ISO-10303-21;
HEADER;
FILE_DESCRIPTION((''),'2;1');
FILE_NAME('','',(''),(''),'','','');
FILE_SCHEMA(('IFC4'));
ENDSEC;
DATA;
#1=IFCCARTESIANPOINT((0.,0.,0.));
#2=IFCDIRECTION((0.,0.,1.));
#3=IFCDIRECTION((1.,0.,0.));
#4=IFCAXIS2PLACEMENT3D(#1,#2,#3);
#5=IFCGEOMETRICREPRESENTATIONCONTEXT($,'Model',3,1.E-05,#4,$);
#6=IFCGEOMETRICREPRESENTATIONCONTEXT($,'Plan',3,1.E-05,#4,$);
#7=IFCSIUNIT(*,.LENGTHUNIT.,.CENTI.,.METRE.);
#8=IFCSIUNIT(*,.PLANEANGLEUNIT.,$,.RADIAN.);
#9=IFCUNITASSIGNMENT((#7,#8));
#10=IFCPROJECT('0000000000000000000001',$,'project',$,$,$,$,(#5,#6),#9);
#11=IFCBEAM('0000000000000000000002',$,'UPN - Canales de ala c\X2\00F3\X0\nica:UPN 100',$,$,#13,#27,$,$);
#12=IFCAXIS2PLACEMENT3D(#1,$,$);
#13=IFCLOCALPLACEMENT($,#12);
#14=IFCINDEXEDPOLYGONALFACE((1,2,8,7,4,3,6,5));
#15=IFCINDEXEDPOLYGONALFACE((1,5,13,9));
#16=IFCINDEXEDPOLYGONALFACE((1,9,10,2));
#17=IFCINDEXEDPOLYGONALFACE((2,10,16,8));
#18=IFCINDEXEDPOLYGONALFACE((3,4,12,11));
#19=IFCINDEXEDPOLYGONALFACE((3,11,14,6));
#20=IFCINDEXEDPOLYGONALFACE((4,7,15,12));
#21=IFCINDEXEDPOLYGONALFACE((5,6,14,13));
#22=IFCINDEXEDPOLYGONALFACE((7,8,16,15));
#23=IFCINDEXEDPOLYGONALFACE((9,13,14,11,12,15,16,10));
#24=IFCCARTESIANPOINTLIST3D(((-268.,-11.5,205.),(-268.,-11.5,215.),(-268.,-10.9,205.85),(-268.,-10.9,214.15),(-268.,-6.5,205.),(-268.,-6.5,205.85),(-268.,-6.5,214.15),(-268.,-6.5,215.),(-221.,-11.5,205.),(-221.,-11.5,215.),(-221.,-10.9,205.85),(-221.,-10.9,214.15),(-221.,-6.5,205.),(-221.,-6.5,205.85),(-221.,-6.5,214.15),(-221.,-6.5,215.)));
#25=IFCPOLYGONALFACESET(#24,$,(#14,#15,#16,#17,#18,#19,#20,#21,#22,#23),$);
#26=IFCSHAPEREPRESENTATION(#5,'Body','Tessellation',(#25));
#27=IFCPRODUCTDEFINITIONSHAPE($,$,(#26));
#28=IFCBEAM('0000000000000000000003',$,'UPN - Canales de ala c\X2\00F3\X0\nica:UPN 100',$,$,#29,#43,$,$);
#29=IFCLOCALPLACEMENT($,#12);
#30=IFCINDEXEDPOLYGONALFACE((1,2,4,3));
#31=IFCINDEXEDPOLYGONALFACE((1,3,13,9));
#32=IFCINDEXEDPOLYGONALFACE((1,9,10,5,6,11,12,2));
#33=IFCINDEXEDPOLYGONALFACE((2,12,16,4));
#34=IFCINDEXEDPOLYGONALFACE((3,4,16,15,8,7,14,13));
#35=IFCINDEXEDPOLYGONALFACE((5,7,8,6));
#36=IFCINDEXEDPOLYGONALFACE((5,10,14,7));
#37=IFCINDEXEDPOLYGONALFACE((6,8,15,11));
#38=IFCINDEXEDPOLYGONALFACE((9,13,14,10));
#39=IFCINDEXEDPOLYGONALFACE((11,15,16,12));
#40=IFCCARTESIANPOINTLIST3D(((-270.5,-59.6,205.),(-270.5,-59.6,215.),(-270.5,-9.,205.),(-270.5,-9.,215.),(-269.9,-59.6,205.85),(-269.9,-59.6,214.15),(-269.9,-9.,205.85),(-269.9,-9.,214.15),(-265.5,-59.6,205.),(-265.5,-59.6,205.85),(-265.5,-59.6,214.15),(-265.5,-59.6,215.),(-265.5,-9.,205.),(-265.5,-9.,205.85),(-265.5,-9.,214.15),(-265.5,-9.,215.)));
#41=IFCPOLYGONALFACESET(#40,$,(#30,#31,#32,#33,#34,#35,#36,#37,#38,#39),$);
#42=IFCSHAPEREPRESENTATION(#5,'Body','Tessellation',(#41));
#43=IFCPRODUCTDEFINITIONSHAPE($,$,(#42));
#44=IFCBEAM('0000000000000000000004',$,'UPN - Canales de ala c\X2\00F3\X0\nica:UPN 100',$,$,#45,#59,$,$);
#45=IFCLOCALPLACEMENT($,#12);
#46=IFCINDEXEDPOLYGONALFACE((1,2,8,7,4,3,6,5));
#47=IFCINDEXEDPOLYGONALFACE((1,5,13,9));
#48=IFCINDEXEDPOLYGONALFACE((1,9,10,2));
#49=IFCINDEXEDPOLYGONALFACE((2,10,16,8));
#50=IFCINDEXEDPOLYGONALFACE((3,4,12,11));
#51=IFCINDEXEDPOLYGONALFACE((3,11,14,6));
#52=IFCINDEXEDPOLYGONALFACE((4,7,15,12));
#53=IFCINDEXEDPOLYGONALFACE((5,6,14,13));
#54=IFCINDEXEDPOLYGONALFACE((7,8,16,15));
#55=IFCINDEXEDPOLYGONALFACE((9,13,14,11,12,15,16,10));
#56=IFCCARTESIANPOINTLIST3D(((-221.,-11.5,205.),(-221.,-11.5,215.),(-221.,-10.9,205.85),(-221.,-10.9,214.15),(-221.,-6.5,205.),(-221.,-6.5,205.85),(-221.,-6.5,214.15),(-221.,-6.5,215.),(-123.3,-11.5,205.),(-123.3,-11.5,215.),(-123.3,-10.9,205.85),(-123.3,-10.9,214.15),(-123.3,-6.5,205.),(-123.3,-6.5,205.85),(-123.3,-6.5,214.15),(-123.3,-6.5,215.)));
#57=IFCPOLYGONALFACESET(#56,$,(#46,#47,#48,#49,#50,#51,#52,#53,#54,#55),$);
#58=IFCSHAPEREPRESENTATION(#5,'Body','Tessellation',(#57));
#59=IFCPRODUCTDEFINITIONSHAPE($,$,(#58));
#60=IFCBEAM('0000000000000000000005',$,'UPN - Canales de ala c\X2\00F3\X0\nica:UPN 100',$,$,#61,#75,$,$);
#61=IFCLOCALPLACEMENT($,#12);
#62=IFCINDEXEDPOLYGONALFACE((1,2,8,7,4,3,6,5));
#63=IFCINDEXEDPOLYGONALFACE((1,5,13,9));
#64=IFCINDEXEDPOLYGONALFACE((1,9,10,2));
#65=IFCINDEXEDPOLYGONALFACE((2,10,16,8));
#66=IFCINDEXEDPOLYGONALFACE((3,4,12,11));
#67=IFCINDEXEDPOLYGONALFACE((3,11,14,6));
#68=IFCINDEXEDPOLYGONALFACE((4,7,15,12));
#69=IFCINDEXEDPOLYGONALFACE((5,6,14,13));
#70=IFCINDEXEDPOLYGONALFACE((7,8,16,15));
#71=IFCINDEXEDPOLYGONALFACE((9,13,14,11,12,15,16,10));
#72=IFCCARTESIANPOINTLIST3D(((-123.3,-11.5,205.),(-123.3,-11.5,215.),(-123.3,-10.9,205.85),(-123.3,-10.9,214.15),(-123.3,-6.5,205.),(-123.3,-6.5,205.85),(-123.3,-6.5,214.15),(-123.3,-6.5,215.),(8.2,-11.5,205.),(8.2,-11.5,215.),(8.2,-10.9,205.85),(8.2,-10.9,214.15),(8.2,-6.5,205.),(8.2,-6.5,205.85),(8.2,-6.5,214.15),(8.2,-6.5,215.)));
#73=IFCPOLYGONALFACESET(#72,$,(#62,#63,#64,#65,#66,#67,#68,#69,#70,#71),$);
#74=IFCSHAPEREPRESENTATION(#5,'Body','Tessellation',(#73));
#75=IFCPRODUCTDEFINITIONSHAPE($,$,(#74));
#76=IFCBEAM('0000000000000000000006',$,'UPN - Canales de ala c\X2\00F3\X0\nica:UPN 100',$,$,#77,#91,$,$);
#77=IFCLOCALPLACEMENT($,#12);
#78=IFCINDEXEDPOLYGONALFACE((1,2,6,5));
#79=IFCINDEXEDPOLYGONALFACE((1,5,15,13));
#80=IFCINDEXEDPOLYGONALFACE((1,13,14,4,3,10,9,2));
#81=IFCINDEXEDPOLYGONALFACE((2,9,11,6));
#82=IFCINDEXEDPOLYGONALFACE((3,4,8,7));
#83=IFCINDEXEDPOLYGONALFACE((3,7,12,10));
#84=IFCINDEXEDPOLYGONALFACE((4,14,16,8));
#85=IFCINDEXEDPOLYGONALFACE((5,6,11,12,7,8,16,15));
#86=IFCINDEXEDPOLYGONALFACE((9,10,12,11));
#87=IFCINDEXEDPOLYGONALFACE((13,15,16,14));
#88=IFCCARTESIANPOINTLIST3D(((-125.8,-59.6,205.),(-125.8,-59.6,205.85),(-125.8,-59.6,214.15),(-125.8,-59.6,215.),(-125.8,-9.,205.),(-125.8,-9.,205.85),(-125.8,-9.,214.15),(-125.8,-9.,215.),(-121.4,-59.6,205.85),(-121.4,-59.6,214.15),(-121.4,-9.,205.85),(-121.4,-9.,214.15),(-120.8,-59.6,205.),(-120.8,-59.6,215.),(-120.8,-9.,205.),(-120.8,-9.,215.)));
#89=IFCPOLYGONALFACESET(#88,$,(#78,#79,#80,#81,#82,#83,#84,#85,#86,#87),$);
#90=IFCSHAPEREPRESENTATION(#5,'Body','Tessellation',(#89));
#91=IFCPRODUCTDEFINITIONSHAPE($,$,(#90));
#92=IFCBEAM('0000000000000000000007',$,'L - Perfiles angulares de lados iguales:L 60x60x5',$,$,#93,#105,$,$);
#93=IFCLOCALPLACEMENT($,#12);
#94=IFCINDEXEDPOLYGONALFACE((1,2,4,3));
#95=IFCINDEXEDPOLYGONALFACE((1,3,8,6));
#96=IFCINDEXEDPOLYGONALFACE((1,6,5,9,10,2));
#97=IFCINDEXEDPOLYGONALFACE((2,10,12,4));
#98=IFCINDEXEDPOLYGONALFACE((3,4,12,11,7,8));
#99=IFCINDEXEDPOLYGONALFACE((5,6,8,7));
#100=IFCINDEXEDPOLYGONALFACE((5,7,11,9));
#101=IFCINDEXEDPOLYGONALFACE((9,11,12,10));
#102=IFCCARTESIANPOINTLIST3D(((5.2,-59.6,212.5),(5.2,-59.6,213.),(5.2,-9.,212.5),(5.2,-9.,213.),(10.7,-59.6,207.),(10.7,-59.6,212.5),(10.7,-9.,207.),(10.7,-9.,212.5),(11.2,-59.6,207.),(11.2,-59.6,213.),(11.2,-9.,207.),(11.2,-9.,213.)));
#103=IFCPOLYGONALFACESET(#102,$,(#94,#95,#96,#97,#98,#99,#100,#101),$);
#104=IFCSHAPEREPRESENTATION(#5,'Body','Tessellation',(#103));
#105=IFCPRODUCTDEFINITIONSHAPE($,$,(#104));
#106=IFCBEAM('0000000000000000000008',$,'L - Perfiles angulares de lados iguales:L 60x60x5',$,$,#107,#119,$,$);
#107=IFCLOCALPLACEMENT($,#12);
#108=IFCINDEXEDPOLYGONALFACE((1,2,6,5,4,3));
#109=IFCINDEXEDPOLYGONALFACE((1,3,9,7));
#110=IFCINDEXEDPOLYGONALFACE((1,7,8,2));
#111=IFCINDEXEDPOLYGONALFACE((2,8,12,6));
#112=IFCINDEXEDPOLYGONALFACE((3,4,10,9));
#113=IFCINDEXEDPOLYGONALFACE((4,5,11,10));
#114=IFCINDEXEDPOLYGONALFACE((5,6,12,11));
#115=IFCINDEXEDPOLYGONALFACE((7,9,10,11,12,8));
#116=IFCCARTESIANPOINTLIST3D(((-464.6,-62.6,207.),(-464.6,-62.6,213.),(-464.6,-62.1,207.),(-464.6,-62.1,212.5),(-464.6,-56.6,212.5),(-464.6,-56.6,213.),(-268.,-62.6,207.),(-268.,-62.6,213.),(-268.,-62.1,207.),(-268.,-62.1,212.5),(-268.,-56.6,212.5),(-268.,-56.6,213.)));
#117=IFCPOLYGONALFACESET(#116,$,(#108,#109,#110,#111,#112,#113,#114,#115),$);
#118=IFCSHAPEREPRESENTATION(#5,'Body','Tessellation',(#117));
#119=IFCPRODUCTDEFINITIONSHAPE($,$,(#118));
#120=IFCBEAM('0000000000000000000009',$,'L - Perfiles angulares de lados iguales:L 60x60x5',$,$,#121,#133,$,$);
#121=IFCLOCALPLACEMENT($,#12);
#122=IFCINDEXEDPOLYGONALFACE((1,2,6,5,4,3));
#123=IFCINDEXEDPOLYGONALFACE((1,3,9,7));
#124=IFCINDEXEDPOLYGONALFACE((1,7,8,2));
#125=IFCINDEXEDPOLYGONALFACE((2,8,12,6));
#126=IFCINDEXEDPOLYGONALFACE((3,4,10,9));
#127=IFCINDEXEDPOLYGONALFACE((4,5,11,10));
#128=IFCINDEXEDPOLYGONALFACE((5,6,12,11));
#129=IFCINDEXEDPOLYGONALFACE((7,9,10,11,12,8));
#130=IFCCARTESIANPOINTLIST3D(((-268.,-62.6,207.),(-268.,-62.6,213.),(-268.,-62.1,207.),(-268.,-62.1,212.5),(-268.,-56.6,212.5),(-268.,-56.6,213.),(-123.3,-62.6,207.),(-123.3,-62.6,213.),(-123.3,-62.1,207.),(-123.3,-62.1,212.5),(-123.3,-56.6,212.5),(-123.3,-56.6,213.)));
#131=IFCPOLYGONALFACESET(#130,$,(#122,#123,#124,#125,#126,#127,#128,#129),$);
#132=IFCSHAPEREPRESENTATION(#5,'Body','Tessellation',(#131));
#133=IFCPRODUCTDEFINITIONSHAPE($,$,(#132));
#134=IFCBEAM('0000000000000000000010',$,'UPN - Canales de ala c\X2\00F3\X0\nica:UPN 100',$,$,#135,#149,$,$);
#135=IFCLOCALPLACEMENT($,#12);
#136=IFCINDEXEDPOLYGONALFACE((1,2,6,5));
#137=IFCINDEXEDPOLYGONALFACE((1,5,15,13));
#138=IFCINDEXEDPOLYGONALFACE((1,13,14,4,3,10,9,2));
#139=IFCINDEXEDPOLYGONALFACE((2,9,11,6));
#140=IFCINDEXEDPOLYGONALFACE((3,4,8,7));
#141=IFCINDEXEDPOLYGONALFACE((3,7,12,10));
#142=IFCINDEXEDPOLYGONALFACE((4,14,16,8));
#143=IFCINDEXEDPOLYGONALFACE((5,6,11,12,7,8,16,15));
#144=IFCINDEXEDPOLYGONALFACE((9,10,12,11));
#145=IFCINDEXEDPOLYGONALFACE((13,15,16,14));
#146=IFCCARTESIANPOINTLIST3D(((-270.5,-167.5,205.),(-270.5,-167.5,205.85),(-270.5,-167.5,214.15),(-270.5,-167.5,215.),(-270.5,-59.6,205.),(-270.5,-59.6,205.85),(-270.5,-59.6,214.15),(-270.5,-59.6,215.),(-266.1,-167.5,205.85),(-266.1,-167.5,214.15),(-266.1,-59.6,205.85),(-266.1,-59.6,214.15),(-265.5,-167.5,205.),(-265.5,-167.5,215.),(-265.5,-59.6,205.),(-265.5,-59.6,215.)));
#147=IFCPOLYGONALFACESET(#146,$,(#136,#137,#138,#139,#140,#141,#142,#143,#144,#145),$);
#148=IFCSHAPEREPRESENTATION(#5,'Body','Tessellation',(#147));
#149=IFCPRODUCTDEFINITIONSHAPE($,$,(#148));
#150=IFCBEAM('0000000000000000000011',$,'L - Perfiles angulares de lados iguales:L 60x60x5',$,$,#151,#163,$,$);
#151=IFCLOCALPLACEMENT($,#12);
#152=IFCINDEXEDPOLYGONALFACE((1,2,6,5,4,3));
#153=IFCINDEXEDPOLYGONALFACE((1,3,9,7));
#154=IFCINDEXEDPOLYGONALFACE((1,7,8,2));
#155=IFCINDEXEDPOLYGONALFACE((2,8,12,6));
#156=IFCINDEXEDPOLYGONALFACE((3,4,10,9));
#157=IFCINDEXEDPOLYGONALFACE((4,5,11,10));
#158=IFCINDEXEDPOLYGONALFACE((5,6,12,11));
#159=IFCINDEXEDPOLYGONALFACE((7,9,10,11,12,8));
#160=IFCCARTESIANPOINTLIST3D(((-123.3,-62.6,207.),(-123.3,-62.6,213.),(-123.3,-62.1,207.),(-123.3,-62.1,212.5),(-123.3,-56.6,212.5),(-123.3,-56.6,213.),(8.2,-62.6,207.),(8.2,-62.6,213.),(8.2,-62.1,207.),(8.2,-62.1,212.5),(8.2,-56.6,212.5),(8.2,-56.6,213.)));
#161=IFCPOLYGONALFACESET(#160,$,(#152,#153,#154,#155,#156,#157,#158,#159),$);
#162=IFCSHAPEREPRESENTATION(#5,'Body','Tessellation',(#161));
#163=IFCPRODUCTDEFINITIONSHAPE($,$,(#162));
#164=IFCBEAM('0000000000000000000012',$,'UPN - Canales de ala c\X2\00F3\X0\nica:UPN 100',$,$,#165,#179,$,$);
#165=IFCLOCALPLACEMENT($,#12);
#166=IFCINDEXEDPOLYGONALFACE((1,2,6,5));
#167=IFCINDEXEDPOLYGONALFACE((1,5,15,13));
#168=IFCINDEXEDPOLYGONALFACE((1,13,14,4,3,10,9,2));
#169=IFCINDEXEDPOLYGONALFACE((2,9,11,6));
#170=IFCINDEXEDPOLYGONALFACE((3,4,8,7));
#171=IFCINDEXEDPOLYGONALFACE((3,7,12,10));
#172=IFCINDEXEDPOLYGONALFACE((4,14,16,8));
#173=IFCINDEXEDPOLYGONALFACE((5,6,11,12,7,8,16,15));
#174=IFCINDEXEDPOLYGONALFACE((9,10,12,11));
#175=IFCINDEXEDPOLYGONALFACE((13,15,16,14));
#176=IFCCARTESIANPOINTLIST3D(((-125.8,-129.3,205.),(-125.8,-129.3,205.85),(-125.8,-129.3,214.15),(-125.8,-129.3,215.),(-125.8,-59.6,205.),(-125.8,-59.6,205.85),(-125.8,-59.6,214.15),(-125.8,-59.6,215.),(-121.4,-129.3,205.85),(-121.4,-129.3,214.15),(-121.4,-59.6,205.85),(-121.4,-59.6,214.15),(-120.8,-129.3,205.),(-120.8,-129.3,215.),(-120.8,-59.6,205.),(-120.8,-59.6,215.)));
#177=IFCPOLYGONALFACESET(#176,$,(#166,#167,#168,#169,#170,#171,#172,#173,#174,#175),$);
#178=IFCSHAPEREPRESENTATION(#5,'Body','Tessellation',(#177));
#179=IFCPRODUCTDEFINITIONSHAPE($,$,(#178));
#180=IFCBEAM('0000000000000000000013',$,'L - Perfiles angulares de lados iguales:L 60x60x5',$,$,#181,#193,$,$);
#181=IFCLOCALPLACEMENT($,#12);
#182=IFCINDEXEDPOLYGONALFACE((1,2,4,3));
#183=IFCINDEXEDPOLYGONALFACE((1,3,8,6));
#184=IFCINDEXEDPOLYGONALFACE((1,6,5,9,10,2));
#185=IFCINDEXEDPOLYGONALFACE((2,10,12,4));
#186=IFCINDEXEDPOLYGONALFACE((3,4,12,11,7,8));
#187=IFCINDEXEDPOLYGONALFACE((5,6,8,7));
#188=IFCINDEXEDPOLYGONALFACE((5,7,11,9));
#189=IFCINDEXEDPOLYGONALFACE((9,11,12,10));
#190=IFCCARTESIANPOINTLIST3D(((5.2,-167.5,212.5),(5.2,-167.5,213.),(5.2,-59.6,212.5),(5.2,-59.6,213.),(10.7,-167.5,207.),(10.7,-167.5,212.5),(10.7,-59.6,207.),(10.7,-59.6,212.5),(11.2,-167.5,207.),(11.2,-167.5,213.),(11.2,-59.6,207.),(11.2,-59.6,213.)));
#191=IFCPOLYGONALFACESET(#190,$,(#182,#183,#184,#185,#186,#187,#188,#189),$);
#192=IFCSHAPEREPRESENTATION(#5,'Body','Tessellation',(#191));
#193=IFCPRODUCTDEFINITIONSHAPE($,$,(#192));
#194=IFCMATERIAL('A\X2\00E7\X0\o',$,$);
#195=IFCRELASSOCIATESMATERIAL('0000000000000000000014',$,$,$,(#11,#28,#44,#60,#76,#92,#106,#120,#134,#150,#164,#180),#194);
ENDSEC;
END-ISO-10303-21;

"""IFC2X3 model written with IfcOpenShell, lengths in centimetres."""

from ifc_helpers import new_model, si_unit, frame, frame_2d, origin_with_axes, origin_2d_with_axis, place, context, project, polyline, u_section, outline, extrude, material, element, save


model = new_model("IFC2X3")

# Units and contexts
model_context = context("Model", 3, precision=1e-05, world=origin_with_axes())
plan_context = context("Plan", 3, precision=1e-05, world=origin_with_axes())
ifc_project = project(units=[si_unit("LENGTHUNIT", "METRE", prefix="CENTI"), si_unit("PLANEANGLEUNIT", "RADIAN")], contexts=[model_context, plan_context])

# Shared definitions
ifc_material = material(Name="Aço")

# Beams
beam_1_placement = place(None, frame((-221.0, -9.0, 210.0), z_axis=(-1.0, 0.0, 0.0), x_axis=(0.0, 1.0, 0.0)))
element("IfcBeam", 1, at=beam_1_placement, material=ifc_material, Name="UPN - Canales de ala cónica:UPN 100", context=model_context, shape_type="SweptSolid", body=[
    extrude(u_section(Depth=10.0, FlangeWidth=5.0, WebThickness=0.6, FlangeThickness=0.85, FilletRadius=0.0, EdgeRadius=0.0, FlangeSlope=0.0, CentreOfGravityInX=0.0, at=frame_2d((0.0, 0.0), x_axis=(1.0, 0.0))), origin_with_axes(), (0.0, 0.0, 1.0), 47.0),
])
beam_2_placement = place(None, frame((-268.0, -59.6, 210.0), z_axis=(0.0, 1.0, 0.0), x_axis=(1.0, 0.0, 0.0)))
element("IfcBeam", 2, at=beam_2_placement, material=ifc_material, Name="UPN - Canales de ala cónica:UPN 100", context=model_context, shape_type="SweptSolid", body=[
    extrude(u_section(Depth=10.0, FlangeWidth=5.0, WebThickness=0.6, FlangeThickness=0.85, FilletRadius=0.0, EdgeRadius=0.0, FlangeSlope=0.0, CentreOfGravityInX=0.0, at=origin_2d_with_axis()), origin_with_axes(), (0.0, 0.0, 1.0), 50.6),
])
beam_3_placement = place(None, frame((-123.3, -9.0, 210.0), z_axis=(-1.0, 0.0, 0.0), x_axis=(0.0, 1.0, 0.0)))
element("IfcBeam", 3, at=beam_3_placement, material=ifc_material, Name="UPN - Canales de ala cónica:UPN 100", context=model_context, shape_type="SweptSolid", body=[
    extrude(u_section(Depth=10.0, FlangeWidth=5.0, WebThickness=0.6, FlangeThickness=0.85, FilletRadius=0.0, EdgeRadius=0.0, FlangeSlope=0.0, CentreOfGravityInX=0.0, at=frame_2d((0.0, 0.0), x_axis=(1.0, 0.0))), origin_with_axes(), (0.0, 0.0, 1.0), 97.7),
])
beam_4_placement = place(None, frame((8.2, -9.0, 210.0), z_axis=(-1.0, 0.0, 0.0), x_axis=(0.0, 1.0, 0.0)))
element("IfcBeam", 4, at=beam_4_placement, material=ifc_material, Name="UPN - Canales de ala cónica:UPN 100", context=model_context, shape_type="SweptSolid", body=[
    extrude(u_section(Depth=10.0, FlangeWidth=5.0, WebThickness=0.6, FlangeThickness=0.85, FilletRadius=0.0, EdgeRadius=0.0, FlangeSlope=0.0, CentreOfGravityInX=0.0, at=frame_2d((0.0, 0.0), x_axis=(1.0, 0.0))), origin_with_axes(), (0.0, 0.0, 1.0), 131.5),
])
beam_5_placement = place(None, frame((-123.3, -59.6, 210.0), z_axis=(0.0, 1.0, 0.0), x_axis=(-1.0, 0.0, 0.0)))
element("IfcBeam", 5, at=beam_5_placement, material=ifc_material, Name="UPN - Canales de ala cónica:UPN 100", context=model_context, shape_type="SweptSolid", body=[
    extrude(u_section(Depth=10.0, FlangeWidth=5.0, WebThickness=0.6, FlangeThickness=0.85, FilletRadius=0.0, EdgeRadius=0.0, FlangeSlope=0.0, CentreOfGravityInX=0.0, at=origin_2d_with_axis()), origin_with_axes(), (0.0, 0.0, 1.0), 50.6),
])
beam_6_placement = place(None, frame((8.2, -59.6, 210.0), z_axis=(0.0, 1.0, 0.0), x_axis=(-1.0, 0.0, 0.0)))
element("IfcBeam", 6, at=beam_6_placement, material=ifc_material, Name="L - Perfiles angulares de lados iguales:L 60x60x5", context=model_context, shape_type="SweptSolid", body=[
    extrude(outline(polyline([(-3.0, -3.0), (-2.5, -3.0), (-2.5, 2.5), (3.0, 2.5), (3.0, 3.0), (-3.0, 3.0), (-3.0, -3.0)])), origin_with_axes(), (0.0, 0.0, 1.0), 50.6),
])
beam_7_placement = place(None, frame((-268.0, -59.6, 210.0), z_axis=(-1.0, 0.0, 0.0), x_axis=(0.0, -1.0, 0.0)))
element("IfcBeam", 7, at=beam_7_placement, material=ifc_material, Name="L - Perfiles angulares de lados iguales:L 60x60x5", context=model_context, shape_type="SweptSolid", body=[
    extrude(outline(polyline([(3.0, -3.0), (3.0, 3.0), (-3.0, 3.0), (-3.0, 2.5), (2.5, 2.5), (2.5, -3.0), (3.0, -3.0)])), origin_with_axes(), (0.0, 0.0, 1.0), 196.6),
])
beam_8_placement = place(None, frame((-123.3, -59.6, 210.0), z_axis=(-1.0, 0.0, 0.0), x_axis=(0.0, -1.0, 0.0)))
element("IfcBeam", 8, at=beam_8_placement, material=ifc_material, Name="L - Perfiles angulares de lados iguales:L 60x60x5", context=model_context, shape_type="SweptSolid", body=[
    extrude(outline(polyline([(3.0, -3.0), (3.0, 3.0), (-3.0, 3.0), (-3.0, 2.5), (2.5, 2.5), (2.5, -3.0), (3.0, -3.0)])), origin_with_axes(), (0.0, 0.0, 1.0), 144.7),
])
beam_9_placement = place(None, frame((-268.0, -167.5, 210.0), z_axis=(0.0, 1.0, 0.0), x_axis=(-1.0, 0.0, 0.0)))
element("IfcBeam", 9, at=beam_9_placement, material=ifc_material, Name="UPN - Canales de ala cónica:UPN 100", context=model_context, shape_type="SweptSolid", body=[
    extrude(u_section(Depth=10.0, FlangeWidth=5.0, WebThickness=0.6, FlangeThickness=0.85, FilletRadius=0.0, EdgeRadius=0.0, FlangeSlope=0.0, CentreOfGravityInX=0.0, at=origin_2d_with_axis()), origin_with_axes(), (0.0, 0.0, 1.0), 107.9),
])
beam_10_placement = place(None, frame((8.2, -59.6, 210.0), z_axis=(-1.0, 0.0, 0.0), x_axis=(0.0, 0.0, -1.0)))
element("IfcBeam", 10, at=beam_10_placement, material=ifc_material, Name="L - Perfiles angulares de lados iguales:L 60x60x5", context=model_context, shape_type="SweptSolid", body=[
    extrude(outline(polyline([(-3.0, -3.0), (-2.5, -3.0), (-2.5, 2.5), (3.0, 2.5), (3.0, 3.0), (-3.0, 3.0), (-3.0, -3.0)])), origin_with_axes(), (0.0, 0.0, 1.0), 131.5),
])
beam_11_placement = place(None, frame((-123.3, -129.3, 210.0), z_axis=(0.0, 1.0, 0.0), x_axis=(-1.0, 0.0, 0.0)))
element("IfcBeam", 11, at=beam_11_placement, material=ifc_material, Name="UPN - Canales de ala cónica:UPN 100", context=model_context, shape_type="SweptSolid", body=[
    extrude(u_section(Depth=10.0, FlangeWidth=5.0, WebThickness=0.6, FlangeThickness=0.85, FilletRadius=0.0, EdgeRadius=0.0, FlangeSlope=0.0, CentreOfGravityInX=0.0, at=origin_2d_with_axis()), origin_with_axes(), (0.0, 0.0, 1.0), 69.7),
])
beam_12_placement = place(None, frame((8.2, -167.5, 210.0), z_axis=(0.0, 1.0, 0.0), x_axis=(-1.0, 0.0, 0.0)))
element("IfcBeam", 12, at=beam_12_placement, material=ifc_material, Name="L - Perfiles angulares de lados iguales:L 60x60x5", context=model_context, shape_type="SweptSolid", body=[
    extrude(outline(polyline([(-3.0, -3.0), (-2.5, -3.0), (-2.5, 2.5), (3.0, 2.5), (3.0, 3.0), (-3.0, 3.0), (-3.0, -3.0)])), origin_with_axes(), (0.0, 0.0, 1.0), 107.9),
])

save(model, "model.ifc")
